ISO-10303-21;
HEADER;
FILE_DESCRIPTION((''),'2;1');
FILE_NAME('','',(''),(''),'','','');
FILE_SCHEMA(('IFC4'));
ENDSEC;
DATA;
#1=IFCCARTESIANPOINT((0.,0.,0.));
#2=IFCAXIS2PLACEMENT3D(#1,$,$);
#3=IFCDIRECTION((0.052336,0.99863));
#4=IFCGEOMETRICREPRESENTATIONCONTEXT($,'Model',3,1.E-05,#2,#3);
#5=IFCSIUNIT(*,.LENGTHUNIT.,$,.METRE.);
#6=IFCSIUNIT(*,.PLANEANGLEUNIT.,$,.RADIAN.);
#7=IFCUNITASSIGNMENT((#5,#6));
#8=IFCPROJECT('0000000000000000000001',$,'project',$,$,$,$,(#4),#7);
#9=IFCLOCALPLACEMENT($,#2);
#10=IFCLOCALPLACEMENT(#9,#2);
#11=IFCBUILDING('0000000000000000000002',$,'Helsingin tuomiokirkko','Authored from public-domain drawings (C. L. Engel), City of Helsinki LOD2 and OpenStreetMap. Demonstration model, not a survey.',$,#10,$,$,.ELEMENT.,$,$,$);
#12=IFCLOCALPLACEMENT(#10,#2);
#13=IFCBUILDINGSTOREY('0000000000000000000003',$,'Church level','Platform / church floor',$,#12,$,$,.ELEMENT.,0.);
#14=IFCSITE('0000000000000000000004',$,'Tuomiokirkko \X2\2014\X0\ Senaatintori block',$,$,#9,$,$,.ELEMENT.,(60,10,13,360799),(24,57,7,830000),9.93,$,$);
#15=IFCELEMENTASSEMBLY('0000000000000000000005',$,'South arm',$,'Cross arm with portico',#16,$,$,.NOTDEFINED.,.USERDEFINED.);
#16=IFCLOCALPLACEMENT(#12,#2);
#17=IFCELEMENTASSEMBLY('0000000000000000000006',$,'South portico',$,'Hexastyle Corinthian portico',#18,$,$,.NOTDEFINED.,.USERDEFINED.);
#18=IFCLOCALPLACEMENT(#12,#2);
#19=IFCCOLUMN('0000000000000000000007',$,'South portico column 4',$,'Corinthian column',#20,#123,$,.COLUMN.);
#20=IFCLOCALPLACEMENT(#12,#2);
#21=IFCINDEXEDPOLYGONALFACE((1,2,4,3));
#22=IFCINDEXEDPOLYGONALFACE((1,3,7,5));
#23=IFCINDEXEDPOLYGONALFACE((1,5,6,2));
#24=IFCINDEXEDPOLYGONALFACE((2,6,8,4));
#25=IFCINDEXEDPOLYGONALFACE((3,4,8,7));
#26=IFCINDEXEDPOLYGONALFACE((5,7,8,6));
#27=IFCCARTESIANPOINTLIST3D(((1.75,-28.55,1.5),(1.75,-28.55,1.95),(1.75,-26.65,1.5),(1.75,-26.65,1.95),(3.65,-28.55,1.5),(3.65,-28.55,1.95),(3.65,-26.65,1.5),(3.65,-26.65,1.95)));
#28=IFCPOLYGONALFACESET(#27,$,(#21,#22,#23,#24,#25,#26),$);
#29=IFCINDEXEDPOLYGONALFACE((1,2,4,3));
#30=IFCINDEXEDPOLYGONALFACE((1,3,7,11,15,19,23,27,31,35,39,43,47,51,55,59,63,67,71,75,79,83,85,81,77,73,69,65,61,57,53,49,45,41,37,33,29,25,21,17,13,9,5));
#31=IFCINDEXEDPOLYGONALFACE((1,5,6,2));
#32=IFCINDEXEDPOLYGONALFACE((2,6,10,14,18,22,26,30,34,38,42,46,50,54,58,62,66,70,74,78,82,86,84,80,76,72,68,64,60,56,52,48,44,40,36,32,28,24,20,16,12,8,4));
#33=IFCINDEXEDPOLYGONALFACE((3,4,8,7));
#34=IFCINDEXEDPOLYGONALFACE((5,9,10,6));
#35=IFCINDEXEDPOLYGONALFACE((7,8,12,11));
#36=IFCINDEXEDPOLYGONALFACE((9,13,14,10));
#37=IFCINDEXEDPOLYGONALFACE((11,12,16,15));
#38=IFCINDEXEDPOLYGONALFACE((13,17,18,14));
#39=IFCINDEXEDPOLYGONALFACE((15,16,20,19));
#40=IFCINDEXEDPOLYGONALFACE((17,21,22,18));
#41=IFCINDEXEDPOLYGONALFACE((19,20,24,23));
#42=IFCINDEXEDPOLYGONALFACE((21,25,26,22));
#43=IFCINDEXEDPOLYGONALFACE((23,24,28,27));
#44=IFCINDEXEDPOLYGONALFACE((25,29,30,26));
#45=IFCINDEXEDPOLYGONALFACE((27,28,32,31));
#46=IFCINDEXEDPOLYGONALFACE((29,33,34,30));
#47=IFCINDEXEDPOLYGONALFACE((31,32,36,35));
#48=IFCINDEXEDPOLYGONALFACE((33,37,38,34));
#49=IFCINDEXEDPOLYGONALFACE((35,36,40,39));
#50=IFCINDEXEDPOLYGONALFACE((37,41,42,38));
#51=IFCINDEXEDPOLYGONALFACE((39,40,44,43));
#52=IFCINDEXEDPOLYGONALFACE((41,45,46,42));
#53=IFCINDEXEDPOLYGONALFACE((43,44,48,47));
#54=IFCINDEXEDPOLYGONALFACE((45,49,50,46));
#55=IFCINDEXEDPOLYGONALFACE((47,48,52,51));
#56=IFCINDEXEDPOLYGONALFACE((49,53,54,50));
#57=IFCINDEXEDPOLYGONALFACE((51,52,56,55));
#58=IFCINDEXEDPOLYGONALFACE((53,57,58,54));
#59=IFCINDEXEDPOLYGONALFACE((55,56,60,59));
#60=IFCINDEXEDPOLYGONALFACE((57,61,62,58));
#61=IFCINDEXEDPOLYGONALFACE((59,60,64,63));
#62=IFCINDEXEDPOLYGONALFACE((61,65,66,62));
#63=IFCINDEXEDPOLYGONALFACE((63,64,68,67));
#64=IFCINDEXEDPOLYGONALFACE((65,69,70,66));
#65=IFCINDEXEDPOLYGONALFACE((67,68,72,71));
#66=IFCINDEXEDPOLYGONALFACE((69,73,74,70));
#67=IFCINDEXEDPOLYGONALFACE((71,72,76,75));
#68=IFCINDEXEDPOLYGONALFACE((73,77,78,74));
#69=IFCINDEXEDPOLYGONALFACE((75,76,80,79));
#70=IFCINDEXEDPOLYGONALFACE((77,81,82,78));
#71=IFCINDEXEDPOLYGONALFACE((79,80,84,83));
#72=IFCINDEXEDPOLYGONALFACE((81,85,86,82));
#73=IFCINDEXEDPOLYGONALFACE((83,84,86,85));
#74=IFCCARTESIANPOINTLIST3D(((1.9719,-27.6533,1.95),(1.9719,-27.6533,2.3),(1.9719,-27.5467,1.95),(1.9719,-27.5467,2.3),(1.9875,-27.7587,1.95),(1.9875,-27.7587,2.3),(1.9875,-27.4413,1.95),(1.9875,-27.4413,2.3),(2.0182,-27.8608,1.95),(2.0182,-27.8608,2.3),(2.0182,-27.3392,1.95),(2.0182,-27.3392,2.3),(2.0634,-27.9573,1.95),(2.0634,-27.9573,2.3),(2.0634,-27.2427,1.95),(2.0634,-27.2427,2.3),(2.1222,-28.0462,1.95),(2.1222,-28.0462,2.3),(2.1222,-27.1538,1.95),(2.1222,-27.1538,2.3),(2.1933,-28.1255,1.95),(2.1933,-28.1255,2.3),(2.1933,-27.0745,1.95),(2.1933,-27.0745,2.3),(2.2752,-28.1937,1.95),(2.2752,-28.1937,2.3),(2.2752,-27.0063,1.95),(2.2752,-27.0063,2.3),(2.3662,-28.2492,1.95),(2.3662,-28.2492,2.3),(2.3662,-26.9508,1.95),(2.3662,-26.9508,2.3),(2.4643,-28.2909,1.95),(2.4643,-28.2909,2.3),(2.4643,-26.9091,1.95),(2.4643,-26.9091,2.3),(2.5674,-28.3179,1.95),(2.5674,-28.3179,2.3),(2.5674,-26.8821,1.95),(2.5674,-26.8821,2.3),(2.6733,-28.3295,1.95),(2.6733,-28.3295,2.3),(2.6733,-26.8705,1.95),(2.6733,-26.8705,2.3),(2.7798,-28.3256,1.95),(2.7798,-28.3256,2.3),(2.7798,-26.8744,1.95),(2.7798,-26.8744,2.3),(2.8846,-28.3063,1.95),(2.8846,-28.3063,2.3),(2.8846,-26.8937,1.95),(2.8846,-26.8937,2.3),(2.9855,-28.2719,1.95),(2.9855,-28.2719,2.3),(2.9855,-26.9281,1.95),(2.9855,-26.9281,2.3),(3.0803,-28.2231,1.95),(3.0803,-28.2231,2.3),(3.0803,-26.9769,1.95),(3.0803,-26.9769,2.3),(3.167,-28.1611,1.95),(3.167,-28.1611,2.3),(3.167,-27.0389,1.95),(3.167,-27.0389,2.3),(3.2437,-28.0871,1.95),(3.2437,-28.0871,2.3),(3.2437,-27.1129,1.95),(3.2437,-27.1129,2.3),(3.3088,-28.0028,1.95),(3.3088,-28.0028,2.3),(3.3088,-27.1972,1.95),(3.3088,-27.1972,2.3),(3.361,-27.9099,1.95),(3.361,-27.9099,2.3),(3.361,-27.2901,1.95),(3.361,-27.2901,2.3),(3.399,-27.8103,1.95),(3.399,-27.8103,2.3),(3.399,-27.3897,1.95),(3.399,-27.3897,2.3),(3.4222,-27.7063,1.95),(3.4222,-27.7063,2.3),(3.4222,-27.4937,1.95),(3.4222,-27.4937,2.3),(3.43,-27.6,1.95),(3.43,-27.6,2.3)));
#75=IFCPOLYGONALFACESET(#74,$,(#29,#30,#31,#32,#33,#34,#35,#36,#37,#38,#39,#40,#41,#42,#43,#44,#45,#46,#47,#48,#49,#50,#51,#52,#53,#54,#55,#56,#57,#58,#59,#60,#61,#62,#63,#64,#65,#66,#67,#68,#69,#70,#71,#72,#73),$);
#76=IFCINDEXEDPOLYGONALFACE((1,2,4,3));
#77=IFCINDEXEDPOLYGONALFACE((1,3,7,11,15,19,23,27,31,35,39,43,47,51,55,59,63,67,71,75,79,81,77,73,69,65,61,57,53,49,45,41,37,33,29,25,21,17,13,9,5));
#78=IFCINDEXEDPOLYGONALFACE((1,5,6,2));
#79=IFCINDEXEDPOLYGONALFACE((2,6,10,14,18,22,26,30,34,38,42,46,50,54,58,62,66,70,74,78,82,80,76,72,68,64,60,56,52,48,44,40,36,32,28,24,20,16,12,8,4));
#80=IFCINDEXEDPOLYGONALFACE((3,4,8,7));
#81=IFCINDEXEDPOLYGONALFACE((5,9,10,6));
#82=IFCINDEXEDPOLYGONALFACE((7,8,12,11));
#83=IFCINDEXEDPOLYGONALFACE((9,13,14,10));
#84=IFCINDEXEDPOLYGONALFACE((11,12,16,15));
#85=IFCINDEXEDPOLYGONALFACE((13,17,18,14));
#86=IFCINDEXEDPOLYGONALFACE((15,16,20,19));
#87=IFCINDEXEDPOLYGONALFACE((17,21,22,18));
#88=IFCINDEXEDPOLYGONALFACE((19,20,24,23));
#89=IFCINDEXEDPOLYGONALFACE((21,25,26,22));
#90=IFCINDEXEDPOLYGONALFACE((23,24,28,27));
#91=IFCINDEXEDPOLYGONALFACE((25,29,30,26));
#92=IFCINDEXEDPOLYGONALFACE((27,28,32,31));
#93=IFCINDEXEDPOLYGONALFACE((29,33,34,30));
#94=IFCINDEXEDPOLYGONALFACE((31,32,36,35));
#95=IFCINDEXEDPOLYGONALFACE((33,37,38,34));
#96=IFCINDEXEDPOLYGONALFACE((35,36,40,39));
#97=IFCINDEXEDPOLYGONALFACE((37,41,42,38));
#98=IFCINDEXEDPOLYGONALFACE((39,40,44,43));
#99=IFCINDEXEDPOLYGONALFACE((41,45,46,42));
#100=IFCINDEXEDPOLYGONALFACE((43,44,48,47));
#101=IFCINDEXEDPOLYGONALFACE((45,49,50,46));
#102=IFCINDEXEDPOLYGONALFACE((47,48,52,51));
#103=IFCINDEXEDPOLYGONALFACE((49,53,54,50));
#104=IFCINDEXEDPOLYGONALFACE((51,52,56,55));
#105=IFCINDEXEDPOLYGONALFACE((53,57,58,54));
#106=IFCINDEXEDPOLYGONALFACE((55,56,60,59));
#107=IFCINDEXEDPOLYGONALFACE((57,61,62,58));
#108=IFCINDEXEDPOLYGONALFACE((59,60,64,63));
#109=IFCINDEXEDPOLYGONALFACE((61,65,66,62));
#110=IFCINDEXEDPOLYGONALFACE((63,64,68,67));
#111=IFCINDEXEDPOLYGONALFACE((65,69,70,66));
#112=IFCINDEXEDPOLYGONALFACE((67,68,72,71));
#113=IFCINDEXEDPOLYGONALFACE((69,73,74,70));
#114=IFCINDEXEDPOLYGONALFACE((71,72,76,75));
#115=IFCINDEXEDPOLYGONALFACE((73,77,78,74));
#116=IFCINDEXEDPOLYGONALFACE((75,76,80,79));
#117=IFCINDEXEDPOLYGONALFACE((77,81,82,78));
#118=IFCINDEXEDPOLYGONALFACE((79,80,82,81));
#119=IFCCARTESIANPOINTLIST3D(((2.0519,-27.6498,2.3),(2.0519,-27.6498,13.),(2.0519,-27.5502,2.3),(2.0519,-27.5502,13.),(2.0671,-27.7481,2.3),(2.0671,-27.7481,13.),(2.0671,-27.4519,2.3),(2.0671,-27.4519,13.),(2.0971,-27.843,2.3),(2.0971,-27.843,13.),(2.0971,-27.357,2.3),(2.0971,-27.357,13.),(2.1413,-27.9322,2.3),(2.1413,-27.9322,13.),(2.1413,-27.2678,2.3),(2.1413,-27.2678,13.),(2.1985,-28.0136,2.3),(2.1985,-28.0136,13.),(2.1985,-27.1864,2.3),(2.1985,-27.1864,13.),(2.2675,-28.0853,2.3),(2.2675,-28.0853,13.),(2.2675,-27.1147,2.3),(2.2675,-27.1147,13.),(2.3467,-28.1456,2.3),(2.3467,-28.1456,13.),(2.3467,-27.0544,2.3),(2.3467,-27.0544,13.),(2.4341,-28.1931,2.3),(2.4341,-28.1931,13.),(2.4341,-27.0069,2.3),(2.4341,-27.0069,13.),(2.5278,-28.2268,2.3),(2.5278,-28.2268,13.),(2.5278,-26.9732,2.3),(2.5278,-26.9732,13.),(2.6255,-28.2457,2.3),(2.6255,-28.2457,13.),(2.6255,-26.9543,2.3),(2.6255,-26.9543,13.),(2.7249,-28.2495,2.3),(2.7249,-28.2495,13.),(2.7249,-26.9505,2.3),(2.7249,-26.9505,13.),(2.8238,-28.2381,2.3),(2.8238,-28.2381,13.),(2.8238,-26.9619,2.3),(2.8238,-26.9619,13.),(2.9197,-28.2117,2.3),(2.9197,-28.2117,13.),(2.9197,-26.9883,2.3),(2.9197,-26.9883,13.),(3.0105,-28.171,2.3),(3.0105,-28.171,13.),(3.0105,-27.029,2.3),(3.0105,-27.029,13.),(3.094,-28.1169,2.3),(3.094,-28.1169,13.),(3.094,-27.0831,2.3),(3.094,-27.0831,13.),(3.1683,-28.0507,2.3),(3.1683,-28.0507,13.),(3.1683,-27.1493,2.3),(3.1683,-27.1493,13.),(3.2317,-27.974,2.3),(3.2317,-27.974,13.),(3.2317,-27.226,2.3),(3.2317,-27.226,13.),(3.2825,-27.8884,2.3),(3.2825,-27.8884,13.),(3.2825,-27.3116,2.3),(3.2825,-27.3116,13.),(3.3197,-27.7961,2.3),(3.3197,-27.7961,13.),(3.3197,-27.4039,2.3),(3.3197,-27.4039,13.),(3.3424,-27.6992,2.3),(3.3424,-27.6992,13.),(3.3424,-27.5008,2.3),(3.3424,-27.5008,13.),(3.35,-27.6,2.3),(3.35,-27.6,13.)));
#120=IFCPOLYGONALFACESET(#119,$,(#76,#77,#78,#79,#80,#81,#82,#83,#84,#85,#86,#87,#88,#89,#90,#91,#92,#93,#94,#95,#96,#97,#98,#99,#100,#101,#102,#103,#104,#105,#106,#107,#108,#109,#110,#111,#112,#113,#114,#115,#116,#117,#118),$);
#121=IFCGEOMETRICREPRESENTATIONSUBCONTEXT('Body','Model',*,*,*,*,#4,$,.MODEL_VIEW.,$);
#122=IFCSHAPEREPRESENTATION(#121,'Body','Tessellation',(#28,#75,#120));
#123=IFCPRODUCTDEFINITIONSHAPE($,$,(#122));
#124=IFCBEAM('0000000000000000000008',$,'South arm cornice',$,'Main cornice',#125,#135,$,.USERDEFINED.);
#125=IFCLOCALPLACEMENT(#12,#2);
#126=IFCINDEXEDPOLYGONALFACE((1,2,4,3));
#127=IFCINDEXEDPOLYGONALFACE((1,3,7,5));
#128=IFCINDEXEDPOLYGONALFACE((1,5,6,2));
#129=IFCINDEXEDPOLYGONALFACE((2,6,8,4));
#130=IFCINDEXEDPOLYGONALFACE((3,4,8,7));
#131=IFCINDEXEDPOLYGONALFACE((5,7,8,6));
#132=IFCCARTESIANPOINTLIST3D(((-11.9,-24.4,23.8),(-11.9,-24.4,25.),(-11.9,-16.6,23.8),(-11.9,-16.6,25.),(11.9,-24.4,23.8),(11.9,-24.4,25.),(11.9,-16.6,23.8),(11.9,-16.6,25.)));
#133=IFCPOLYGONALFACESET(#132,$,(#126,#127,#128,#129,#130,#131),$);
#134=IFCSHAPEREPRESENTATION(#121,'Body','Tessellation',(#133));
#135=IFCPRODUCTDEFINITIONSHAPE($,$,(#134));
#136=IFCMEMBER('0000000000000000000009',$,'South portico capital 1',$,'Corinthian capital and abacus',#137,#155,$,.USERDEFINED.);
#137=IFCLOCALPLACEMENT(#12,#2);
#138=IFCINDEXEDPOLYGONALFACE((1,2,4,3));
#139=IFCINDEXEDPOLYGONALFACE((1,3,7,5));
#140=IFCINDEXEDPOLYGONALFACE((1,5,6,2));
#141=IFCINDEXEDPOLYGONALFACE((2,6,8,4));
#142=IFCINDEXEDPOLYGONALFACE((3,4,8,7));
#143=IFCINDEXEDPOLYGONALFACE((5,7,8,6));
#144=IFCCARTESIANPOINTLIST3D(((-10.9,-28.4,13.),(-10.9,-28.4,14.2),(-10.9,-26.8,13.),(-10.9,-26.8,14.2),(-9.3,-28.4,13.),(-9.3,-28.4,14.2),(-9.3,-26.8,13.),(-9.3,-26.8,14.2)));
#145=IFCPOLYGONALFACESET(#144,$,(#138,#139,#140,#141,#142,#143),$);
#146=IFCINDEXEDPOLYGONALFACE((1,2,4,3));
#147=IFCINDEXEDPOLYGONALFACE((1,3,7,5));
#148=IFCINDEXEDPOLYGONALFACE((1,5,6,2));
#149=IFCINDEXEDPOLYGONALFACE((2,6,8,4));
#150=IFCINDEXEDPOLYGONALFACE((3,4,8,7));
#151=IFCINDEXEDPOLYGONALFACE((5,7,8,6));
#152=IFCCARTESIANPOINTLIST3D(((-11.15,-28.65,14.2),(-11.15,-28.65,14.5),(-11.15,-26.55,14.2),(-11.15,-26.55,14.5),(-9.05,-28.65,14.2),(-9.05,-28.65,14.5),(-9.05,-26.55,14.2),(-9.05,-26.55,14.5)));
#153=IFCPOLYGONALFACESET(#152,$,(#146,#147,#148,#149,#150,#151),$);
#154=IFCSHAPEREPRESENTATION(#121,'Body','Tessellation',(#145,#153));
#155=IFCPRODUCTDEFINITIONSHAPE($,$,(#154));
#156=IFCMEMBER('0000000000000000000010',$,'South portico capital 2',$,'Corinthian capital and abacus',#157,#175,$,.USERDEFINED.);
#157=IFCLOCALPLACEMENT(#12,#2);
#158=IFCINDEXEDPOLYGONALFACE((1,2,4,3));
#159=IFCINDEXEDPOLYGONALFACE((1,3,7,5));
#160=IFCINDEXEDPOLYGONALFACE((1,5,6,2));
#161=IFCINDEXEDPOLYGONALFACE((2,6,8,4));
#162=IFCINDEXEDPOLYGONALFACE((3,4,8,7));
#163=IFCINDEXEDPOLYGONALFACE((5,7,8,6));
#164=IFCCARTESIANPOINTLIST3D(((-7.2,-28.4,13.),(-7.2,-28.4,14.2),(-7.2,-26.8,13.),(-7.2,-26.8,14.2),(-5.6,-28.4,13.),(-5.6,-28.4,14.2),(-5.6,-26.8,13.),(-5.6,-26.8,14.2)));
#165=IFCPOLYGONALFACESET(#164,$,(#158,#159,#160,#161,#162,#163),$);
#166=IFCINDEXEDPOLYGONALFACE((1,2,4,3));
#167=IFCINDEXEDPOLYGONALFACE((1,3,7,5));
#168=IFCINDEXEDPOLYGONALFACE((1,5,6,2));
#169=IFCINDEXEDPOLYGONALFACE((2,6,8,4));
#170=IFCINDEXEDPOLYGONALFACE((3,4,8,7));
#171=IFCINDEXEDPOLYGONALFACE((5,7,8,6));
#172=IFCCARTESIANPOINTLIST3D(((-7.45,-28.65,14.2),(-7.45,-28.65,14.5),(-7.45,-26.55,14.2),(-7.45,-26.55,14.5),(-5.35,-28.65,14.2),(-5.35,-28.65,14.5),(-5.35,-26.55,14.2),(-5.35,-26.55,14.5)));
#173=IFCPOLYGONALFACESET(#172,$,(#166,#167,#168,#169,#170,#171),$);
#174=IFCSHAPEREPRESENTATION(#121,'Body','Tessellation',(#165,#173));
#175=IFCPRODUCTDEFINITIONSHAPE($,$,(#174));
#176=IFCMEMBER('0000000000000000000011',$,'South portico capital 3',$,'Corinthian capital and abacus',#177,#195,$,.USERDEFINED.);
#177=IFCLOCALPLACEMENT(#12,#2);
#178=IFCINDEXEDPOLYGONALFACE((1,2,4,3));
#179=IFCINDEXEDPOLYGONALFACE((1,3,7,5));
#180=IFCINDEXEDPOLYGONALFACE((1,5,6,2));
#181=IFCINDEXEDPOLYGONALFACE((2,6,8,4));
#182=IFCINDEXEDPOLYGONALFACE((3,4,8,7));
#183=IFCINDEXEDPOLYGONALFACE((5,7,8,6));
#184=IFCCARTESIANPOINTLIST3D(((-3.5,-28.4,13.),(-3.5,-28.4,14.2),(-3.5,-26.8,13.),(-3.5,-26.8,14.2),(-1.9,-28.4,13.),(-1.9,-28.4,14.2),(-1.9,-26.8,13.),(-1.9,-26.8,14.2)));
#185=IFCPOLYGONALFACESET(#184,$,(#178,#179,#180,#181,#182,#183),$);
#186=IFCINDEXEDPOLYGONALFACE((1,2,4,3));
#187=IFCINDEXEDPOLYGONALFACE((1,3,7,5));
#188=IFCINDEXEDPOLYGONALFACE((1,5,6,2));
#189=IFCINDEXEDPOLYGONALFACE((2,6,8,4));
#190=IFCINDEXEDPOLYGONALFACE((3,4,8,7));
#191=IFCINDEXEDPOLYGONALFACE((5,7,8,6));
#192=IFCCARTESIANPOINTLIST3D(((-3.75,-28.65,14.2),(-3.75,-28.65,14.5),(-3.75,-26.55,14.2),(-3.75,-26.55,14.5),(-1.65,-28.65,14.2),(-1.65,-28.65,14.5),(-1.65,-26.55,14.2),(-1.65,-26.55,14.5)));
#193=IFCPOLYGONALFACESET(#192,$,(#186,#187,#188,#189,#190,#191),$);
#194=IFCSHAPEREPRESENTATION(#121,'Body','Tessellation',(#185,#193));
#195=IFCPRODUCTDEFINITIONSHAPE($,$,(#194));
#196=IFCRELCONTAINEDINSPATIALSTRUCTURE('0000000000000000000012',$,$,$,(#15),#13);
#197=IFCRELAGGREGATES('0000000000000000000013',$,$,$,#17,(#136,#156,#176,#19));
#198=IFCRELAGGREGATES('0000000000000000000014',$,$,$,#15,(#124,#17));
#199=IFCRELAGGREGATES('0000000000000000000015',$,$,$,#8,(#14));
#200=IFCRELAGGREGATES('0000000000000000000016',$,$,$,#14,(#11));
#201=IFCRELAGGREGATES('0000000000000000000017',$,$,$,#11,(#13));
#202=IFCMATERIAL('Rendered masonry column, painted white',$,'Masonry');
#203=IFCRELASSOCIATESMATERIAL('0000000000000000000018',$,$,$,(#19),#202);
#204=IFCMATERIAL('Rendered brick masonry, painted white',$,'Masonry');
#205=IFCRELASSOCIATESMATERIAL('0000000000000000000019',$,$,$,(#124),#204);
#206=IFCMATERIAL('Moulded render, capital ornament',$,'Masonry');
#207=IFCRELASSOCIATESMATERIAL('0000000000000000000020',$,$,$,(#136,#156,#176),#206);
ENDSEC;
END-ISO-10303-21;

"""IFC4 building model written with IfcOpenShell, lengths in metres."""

from ifc_helpers import new_model, si_unit, direction, frame, origin, origin_2d_with_axis, place, context, subcontext, project, spatial, rectangle, circle, extrude, material, element, aggregate, save


model = new_model("IFC4")

# Units and contexts
model_context = context("Model", 3, precision=1e-05, world=origin(), true_north=direction((0.052336, 0.99863)))
body_context = subcontext(model_context, "Body", "Model", "MODEL_VIEW")
ifc_project = project(units=[si_unit("LENGTHUNIT", "METRE"), si_unit("PLANEANGLEUNIT", "RADIAN")], contexts=[model_context])

# Site, building, storey
site_placement = place(None, origin())
site = spatial("IfcSite", under=ifc_project, at=site_placement, Name="Tuomiokirkko — Senaatintori block", CompositionType="ELEMENT", RefLatitude=(60, 10, 13, 360799), RefLongitude=(24, 57, 7, 830000), RefElevation=9.93)
building_placement = place(site_placement, origin())
building = spatial("IfcBuilding", under=site, at=building_placement, Name="Helsingin tuomiokirkko", Description="Authored from public-domain drawings (C. L. Engel), City of Helsinki LOD2 and OpenStreetMap. Demonstration model, not a survey.", CompositionType="ELEMENT")
storey_placement = place(building_placement, origin())
storey = spatial("IfcBuildingStorey", under=building, at=storey_placement, Name="Church level", Description="Platform / church floor", CompositionType="ELEMENT", Elevation=0.0)

# Element assemblies, column, beam, members
assembly_1_placement = place(building_placement, origin())
assembly_1 = element("IfcElementAssembly", 1, at=assembly_1_placement, inside=storey, Name="South arm", ObjectType="Cross arm with portico", AssemblyPlace="NOTDEFINED", PredefinedType="USERDEFINED")
ifc_material_1 = material(Name="Rendered brick masonry, painted white", Category="Masonry")
assembly_2_placement = place(building_placement, origin())
assembly_2 = element("IfcElementAssembly", 2, at=assembly_2_placement, Name="South portico", ObjectType="Hexastyle Corinthian portico", AssemblyPlace="NOTDEFINED", PredefinedType="USERDEFINED")
ifc_material_2 = material(Name="Rendered masonry column, painted white", Category="Masonry")
column_1_placement = place(building_placement, origin())
column_1 = element("IfcColumn", 3, at=column_1_placement, material=ifc_material_2, Name="South portico column 4", ObjectType="Corinthian column", PredefinedType="COLUMN", context=body_context, shape_type="SweptSolid", body=[
    extrude(rectangle(XDim=1.9, YDim=1.9, at=origin_2d_with_axis()), frame((2.7, -27.6, 1.5)), (0.0, 0.0, 1.0), 0.45),
    extrude(circle(Radius=0.73, at=origin_2d_with_axis()), frame((2.7, -27.6, 1.95)), (0.0, 0.0, 1.0), 0.35),
    extrude(circle(Radius=0.65, at=origin_2d_with_axis()), frame((2.7, -27.6, 2.3)), (0.0, 0.0, 1.0), 10.7),
])
beam_placement = place(building_placement, origin())
beam = element("IfcBeam", 4, at=beam_placement, material=ifc_material_1, Name="South arm cornice", ObjectType="Main cornice", PredefinedType="USERDEFINED", context=body_context, shape_type="SweptSolid", body=[
    extrude(rectangle(XDim=23.8, YDim=7.8, at=origin_2d_with_axis()), frame((0.0, -20.5, 23.8)), (0.0, 0.0, 1.0), 1.2),
])
ifc_material_3 = material(Name="Moulded render, capital ornament", Category="Masonry")
member_1_placement = place(building_placement, origin())
member_1 = element("IfcMember", 5, at=member_1_placement, material=ifc_material_3, Name="South portico capital 1", ObjectType="Corinthian capital and abacus", PredefinedType="USERDEFINED", context=body_context, shape_type="SweptSolid", body=[
    extrude(rectangle(XDim=1.6, YDim=1.6, at=origin_2d_with_axis()), frame((-10.1, -27.6, 13.0)), (0.0, 0.0, 1.0), 1.2),
    extrude(rectangle(XDim=2.1, YDim=2.1, at=origin_2d_with_axis()), frame((-10.1, -27.6, 14.2)), (0.0, 0.0, 1.0), 0.3),
])
member_2_placement = place(building_placement, origin())
member_2 = element("IfcMember", 6, at=member_2_placement, material=ifc_material_3, Name="South portico capital 2", ObjectType="Corinthian capital and abacus", PredefinedType="USERDEFINED", context=body_context, shape_type="SweptSolid", body=[
    extrude(rectangle(XDim=1.6, YDim=1.6, at=origin_2d_with_axis()), frame((-6.4, -27.6, 13.0)), (0.0, 0.0, 1.0), 1.2),
    extrude(rectangle(XDim=2.1, YDim=2.1, at=origin_2d_with_axis()), frame((-6.4, -27.6, 14.2)), (0.0, 0.0, 1.0), 0.3),
])
member_3_placement = place(building_placement, origin())
member_3 = element("IfcMember", 7, at=member_3_placement, material=ifc_material_3, Name="South portico capital 3", ObjectType="Corinthian capital and abacus", PredefinedType="USERDEFINED", context=body_context, shape_type="SweptSolid", body=[
    extrude(rectangle(XDim=1.6, YDim=1.6, at=origin_2d_with_axis()), frame((-2.7, -27.6, 13.0)), (0.0, 0.0, 1.0), 1.2),
    extrude(rectangle(XDim=2.1, YDim=2.1, at=origin_2d_with_axis()), frame((-2.7, -27.6, 14.2)), (0.0, 0.0, 1.0), 0.3),
])
aggregate(assembly_2, [member_1, member_2, member_3, column_1])
aggregate(assembly_1, [beam, assembly_2])

save(model, "model.ifc")
